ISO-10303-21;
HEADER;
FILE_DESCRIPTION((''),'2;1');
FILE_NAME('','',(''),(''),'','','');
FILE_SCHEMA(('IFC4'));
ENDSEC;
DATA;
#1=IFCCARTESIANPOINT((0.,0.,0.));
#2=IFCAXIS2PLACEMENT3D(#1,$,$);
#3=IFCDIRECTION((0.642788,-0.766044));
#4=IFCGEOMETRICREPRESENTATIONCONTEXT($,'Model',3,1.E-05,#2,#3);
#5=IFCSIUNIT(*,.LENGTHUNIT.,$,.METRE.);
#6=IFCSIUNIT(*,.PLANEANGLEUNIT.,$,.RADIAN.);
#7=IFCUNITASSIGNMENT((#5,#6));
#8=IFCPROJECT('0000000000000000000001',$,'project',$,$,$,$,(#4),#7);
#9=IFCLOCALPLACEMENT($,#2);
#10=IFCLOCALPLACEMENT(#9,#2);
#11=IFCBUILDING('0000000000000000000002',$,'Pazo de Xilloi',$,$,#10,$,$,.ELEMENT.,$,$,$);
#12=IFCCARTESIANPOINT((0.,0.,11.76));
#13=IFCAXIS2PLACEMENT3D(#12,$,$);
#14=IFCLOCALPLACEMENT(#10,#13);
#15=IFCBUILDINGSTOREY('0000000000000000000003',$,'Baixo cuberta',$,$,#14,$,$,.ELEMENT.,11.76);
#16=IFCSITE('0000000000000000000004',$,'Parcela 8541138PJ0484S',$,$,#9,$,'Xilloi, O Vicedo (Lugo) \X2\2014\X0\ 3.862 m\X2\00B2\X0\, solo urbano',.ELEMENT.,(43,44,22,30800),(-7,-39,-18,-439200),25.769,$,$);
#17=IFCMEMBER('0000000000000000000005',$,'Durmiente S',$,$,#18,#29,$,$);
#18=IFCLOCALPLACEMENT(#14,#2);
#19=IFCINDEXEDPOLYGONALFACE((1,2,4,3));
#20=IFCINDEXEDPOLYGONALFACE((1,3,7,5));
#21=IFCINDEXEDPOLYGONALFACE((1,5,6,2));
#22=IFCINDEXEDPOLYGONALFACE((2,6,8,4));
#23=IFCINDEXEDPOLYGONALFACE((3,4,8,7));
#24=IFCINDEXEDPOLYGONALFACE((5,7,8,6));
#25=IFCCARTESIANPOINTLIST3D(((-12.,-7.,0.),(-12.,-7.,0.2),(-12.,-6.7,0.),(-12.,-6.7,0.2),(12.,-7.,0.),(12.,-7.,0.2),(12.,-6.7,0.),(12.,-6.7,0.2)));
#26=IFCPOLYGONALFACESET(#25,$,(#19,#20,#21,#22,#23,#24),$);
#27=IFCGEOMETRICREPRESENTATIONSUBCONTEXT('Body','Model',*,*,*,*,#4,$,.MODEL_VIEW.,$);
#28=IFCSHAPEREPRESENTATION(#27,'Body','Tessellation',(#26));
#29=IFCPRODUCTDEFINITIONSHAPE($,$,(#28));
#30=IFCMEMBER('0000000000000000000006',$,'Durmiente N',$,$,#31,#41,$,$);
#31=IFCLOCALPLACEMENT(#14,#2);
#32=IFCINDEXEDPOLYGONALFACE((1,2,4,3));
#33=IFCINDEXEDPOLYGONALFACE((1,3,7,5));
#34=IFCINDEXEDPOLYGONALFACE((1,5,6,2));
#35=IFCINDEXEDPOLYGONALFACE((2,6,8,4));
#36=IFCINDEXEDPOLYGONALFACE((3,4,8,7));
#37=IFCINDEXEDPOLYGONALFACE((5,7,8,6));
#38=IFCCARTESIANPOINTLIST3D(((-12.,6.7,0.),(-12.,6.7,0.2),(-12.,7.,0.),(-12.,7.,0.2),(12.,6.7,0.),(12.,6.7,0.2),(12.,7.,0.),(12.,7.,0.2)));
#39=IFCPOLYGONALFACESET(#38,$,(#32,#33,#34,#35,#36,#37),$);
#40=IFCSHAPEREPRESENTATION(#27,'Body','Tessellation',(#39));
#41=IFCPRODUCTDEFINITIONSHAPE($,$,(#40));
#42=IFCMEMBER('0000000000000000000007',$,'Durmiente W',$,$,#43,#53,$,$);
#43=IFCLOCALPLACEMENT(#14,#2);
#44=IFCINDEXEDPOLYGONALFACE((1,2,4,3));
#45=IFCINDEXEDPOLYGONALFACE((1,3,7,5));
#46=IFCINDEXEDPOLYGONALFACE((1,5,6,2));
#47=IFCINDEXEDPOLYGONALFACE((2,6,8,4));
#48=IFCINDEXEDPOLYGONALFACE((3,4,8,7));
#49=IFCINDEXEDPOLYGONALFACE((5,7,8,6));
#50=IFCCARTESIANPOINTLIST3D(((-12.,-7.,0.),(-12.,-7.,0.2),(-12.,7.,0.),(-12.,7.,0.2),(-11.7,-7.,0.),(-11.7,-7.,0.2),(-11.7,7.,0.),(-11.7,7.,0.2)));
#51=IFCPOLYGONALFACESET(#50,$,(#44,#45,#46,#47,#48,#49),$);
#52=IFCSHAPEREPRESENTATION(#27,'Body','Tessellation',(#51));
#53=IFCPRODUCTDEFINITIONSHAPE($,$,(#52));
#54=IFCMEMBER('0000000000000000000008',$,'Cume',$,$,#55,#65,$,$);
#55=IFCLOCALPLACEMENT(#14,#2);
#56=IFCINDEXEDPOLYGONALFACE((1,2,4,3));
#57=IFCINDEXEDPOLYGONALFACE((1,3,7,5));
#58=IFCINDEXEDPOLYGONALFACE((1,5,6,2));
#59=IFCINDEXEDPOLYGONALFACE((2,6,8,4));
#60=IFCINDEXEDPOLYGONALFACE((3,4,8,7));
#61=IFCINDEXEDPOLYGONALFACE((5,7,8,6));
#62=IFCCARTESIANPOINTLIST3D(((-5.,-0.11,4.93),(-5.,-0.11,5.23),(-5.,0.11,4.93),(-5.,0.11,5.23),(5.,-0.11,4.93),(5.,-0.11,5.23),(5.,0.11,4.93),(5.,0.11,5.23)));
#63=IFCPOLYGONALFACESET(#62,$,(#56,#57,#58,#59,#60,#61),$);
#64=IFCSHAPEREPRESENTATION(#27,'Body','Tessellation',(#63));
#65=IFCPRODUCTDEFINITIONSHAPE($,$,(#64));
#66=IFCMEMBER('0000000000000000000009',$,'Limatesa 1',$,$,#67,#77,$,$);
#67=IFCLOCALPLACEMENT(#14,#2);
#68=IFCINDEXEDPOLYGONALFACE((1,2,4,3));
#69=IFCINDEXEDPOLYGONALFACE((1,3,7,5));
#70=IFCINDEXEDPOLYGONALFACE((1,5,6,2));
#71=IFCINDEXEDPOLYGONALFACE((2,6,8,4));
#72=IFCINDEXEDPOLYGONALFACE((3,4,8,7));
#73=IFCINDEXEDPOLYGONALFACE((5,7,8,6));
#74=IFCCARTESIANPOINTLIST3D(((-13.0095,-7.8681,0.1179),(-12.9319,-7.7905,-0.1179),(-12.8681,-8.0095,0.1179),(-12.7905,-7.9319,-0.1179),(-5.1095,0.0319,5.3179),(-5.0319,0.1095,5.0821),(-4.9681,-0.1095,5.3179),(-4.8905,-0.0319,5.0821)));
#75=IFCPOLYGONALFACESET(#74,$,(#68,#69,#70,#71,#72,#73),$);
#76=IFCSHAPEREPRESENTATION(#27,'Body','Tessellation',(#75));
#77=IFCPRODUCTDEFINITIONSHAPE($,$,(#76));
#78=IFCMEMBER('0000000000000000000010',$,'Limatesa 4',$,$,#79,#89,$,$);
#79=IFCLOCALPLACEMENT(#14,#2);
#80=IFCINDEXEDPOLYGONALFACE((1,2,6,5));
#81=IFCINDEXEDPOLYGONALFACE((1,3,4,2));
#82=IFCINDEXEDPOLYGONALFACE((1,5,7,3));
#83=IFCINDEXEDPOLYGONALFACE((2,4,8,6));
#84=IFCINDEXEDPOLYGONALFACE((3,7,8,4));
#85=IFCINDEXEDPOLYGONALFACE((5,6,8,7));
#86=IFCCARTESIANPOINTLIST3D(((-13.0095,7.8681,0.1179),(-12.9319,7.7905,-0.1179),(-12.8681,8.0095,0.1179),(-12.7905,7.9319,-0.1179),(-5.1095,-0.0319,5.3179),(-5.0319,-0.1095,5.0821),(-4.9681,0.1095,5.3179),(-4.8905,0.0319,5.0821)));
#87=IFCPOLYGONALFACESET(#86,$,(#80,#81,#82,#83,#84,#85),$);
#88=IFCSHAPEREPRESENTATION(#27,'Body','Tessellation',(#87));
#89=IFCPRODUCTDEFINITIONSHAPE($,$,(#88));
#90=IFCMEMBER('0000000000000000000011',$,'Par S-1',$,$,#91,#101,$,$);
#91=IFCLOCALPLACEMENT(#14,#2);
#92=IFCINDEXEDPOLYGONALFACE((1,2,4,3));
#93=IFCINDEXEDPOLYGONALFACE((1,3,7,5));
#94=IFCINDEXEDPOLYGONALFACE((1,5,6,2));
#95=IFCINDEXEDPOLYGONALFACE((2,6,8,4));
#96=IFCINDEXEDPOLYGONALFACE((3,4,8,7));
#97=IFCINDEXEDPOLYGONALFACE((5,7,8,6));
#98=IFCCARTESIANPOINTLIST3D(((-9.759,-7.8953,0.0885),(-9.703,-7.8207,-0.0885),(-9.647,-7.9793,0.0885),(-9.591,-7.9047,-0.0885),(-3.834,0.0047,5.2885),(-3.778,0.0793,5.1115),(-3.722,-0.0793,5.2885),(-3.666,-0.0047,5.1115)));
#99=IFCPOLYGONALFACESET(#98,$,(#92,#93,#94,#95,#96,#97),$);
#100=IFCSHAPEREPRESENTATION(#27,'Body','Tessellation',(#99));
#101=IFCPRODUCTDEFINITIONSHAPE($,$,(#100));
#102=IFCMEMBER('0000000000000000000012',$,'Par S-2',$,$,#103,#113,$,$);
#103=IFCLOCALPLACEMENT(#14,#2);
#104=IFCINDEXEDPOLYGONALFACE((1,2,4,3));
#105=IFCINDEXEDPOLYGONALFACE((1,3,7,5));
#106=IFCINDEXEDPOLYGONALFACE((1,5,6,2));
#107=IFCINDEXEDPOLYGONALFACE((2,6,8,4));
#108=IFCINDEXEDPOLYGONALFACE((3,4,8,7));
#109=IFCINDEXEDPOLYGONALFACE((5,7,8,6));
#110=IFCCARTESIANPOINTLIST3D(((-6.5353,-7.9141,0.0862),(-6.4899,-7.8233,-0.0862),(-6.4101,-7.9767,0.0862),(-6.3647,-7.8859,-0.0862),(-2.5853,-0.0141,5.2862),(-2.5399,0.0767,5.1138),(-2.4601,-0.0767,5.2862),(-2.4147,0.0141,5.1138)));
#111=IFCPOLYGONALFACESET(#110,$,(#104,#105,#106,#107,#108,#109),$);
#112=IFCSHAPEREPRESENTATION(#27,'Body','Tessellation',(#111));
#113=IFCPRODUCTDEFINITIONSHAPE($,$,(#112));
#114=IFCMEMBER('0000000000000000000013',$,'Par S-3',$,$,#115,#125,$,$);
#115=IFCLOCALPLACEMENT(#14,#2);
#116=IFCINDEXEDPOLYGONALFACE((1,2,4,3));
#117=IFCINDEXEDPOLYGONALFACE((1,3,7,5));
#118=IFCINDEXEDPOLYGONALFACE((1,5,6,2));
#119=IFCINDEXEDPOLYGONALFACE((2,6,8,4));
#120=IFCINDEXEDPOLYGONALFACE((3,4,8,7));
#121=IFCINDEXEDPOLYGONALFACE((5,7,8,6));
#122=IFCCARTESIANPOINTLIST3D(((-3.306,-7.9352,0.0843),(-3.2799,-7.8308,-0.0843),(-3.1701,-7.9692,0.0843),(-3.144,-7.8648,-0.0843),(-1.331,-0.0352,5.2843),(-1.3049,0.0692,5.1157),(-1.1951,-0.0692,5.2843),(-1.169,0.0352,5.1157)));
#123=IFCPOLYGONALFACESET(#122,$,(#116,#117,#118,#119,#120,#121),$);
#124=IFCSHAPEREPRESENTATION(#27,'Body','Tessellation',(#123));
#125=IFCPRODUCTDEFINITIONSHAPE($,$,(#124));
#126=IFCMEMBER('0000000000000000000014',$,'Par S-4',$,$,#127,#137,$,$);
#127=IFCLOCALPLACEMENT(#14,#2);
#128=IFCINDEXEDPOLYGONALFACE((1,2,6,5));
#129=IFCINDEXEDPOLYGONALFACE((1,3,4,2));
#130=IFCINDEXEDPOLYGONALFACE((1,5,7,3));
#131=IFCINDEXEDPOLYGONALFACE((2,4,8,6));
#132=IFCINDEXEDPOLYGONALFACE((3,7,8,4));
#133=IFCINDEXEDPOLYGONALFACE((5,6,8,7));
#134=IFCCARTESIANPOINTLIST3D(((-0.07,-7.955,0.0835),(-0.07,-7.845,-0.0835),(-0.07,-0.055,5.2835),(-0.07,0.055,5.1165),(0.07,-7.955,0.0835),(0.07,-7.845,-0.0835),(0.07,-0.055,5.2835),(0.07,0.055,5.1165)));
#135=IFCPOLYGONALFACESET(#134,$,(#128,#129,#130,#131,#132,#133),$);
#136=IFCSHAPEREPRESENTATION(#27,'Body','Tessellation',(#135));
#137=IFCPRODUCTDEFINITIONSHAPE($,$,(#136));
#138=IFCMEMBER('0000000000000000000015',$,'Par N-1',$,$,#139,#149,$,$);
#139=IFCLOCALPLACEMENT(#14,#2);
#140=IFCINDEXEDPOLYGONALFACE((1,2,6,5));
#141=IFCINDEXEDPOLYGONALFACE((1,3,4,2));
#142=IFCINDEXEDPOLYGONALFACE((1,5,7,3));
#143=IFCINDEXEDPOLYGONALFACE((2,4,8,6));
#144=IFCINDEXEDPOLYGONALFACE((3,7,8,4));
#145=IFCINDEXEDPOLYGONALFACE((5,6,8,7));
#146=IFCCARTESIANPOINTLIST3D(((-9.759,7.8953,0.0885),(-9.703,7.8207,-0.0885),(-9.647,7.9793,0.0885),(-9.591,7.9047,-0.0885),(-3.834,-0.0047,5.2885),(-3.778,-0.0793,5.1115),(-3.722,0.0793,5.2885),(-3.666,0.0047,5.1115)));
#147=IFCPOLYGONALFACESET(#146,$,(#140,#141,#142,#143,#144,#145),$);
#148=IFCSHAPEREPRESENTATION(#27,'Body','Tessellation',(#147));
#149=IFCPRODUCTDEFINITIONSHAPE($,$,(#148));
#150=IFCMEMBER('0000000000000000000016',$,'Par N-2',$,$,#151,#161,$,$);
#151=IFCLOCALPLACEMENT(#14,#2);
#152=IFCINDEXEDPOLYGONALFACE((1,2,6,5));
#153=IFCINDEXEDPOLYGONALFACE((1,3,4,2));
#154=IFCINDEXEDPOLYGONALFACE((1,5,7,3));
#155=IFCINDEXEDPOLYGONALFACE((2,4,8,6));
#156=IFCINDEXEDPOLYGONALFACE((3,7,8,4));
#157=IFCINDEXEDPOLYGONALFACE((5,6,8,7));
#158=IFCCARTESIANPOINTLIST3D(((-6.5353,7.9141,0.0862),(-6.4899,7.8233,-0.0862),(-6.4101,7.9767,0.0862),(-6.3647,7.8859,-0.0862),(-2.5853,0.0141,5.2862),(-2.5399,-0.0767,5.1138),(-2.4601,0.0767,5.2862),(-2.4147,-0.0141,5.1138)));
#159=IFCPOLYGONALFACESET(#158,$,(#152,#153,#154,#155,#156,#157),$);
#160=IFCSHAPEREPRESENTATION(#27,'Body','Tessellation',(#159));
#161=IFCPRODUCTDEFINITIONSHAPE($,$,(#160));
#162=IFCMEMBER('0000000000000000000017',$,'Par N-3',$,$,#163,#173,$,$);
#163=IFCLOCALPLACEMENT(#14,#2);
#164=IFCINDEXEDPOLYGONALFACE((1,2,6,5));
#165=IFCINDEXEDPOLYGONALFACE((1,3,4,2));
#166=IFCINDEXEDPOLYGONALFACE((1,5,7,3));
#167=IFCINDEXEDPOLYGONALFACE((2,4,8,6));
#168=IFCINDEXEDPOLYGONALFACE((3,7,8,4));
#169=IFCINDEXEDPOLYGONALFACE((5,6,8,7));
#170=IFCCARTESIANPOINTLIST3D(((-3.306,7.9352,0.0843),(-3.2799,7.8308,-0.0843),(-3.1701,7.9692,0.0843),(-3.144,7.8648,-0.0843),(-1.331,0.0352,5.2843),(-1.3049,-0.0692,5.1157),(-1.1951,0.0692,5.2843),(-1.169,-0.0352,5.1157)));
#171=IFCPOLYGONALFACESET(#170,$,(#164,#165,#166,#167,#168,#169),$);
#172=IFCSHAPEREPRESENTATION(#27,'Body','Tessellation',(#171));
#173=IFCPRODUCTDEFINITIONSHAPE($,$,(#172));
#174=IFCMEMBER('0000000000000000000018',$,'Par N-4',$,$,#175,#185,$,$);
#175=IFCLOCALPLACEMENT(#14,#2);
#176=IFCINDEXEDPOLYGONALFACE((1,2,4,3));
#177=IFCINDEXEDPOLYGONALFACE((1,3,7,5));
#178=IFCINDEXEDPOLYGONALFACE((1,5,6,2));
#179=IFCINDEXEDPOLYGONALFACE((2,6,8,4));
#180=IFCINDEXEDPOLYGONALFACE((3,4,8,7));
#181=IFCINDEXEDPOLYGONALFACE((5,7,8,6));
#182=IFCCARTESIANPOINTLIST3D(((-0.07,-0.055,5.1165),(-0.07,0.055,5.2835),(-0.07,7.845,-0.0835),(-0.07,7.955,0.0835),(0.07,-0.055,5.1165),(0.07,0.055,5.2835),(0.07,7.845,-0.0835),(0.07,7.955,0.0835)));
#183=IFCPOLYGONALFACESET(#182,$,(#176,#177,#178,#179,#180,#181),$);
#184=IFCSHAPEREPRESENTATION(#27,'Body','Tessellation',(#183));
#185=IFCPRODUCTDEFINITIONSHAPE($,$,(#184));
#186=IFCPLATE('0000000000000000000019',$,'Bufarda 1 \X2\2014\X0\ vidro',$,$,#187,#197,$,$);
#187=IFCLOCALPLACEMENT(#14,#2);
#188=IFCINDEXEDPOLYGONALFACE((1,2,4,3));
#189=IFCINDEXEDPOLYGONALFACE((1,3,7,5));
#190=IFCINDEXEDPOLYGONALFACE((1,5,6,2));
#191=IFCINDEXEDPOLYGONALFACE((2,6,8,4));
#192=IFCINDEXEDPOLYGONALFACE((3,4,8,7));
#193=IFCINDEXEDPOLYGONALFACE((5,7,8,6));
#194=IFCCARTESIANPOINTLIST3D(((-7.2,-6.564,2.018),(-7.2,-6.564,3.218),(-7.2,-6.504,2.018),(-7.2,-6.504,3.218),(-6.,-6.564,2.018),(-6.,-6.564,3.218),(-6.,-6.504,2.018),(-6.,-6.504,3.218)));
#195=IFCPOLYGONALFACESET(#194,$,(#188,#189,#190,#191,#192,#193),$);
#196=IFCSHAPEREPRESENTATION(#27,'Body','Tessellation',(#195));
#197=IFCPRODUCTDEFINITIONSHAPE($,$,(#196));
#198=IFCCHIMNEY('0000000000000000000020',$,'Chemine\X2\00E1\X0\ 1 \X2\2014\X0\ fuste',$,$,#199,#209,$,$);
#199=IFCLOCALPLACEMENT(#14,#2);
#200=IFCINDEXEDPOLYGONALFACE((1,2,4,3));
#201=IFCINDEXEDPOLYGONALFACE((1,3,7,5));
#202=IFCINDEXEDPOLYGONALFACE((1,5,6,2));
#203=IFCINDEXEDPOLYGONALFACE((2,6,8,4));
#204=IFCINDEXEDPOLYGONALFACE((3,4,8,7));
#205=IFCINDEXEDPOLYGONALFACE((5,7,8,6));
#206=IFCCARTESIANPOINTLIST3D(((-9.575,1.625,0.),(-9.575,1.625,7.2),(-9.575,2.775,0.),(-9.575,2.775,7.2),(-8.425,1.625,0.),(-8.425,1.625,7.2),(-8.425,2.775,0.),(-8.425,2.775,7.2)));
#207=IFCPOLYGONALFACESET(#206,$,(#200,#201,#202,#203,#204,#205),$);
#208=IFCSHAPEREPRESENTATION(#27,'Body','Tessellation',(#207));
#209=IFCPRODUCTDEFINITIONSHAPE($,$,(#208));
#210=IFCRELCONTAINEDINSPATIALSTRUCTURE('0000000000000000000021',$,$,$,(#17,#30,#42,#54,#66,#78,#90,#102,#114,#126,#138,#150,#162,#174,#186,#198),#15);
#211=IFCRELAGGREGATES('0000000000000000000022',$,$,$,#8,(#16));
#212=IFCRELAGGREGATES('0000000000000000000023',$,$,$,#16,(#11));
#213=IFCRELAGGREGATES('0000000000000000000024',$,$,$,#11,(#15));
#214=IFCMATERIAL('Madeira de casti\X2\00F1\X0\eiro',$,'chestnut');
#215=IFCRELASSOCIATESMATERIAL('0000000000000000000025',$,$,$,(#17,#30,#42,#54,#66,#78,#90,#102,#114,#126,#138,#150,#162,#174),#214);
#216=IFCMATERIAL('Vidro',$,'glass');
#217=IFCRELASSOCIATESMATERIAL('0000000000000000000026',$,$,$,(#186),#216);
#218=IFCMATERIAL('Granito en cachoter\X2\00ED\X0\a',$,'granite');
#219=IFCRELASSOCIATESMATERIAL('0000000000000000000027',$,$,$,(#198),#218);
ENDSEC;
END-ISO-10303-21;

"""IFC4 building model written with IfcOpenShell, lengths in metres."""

from ifc_helpers import new_model, si_unit, direction, frame, origin, origin_2d, place, context, subcontext, project, spatial, rectangle, extrude, material, element, save


model = new_model("IFC4")

# Units and contexts
model_context = context("Model", 3, precision=1e-05, world=origin(), true_north=direction((0.642788, -0.766044)))
body_context = subcontext(model_context, "Body", "Model", "MODEL_VIEW")
ifc_project = project(units=[si_unit("LENGTHUNIT", "METRE"), si_unit("PLANEANGLEUNIT", "RADIAN")], contexts=[model_context])

# Site, building, storey
site_placement = place(None, origin())
site = spatial("IfcSite", under=ifc_project, at=site_placement, Name="Parcela 8541138PJ0484S", LongName="Xilloi, O Vicedo (Lugo) — 3.862 m², solo urbano", CompositionType="ELEMENT", RefLatitude=(43, 44, 22, 30800), RefLongitude=(-7, -39, -18, -439200), RefElevation=25.769)
building_placement = place(site_placement, origin())
building = spatial("IfcBuilding", under=site, at=building_placement, Name="Pazo de Xilloi", CompositionType="ELEMENT")
storey_placement = place(building_placement, frame((0.0, 0.0, 11.76)))
storey = spatial("IfcBuildingStorey", under=building, at=storey_placement, Name="Baixo cuberta", CompositionType="ELEMENT", Elevation=11.76)

# Members
ifc_material_1 = material(Name="Madeira de castiñeiro", Category="chestnut")
for number, where, name in (
    (1, (0.0, -6.85, 0.1), "Durmiente S"),
    (2, (0.0, 6.85, 0.1), "Durmiente N"),
):
    element("IfcMember", number, at=place(storey_placement, frame(where)), inside=storey, material=ifc_material_1, Name=name, context=body_context, shape_type="SweptSolid", body=[
        extrude(rectangle(XDim=24.0, YDim=0.3, at=origin_2d()), frame((0.0, 0.0, -0.1)), (0.0, 0.0, 1.0), 0.2),
    ])
member_1_placement = place(storey_placement, frame((-11.85, 0.0, 0.1)))
element("IfcMember", 3, at=member_1_placement, inside=storey, material=ifc_material_1, Name="Durmiente W", context=body_context, shape_type="SweptSolid", body=[
    extrude(rectangle(XDim=0.3, YDim=14.0, at=origin_2d()), frame((0.0, 0.0, -0.1)), (0.0, 0.0, 1.0), 0.2),
])
member_2_placement = place(storey_placement, frame((0.0, 0.0, 5.08)))
element("IfcMember", 4, at=member_2_placement, inside=storey, material=ifc_material_1, Name="Cume", context=body_context, shape_type="SweptSolid", body=[
    extrude(rectangle(XDim=10.0, YDim=0.22, at=origin_2d()), frame((0.0, 0.0, -0.15)), (0.0, 0.0, 1.0), 0.3),
])
for number, where, z_axis, x_axis, name in (
    (5, (-8.95, -3.95, 2.6), (-0.298378, -0.298378, 0.90661), (0.64107, 0.64107, 0.42197), "Limatesa 1"),
    (6, (-8.95, 3.95, 2.6), (-0.298378, 0.298378, 0.90661), (0.64107, -0.64107, 0.42197), "Limatesa 4"),
):
    element("IfcMember", number, at=place(storey_placement, frame(where, z_axis=z_axis, x_axis=x_axis)), inside=storey, material=ifc_material_1, Name=name, context=body_context, shape_type="SweptSolid", body=[
        extrude(rectangle(XDim=12.3231, YDim=0.2, at=origin_2d()), frame((0.0, 0.0, -0.13)), (0.0, 0.0, 1.0), 0.26),
    ])
member_3_placement = place(storey_placement, frame((-6.7125, -3.95, 2.6), z_axis=(-0.279559, -0.372745, 0.884821), x_axis=(0.530893, 0.707857, 0.465931)))
element("IfcMember", 7, at=member_3_placement, inside=storey, material=ifc_material_1, Name="Par S-1", context=body_context, shape_type="SweptSolid", body=[
    extrude(rectangle(XDim=11.1604, YDim=0.14, at=origin_2d()), frame((0.0, 0.0, -0.1)), (0.0, 0.0, 1.0), 0.2),
])
member_4_placement = place(storey_placement, frame((-4.475, -3.95, 2.6), z_axis=(-0.22689, -0.45378, 0.861745), x_axis=(0.385384, 0.770768, 0.507341)))
element("IfcMember", 8, at=member_4_placement, inside=storey, material=ifc_material_1, Name="Par S-2", context=body_context, shape_type="SweptSolid", body=[
    extrude(rectangle(XDim=10.2495, YDim=0.14, at=origin_2d()), frame((0.0, 0.0, -0.1)), (0.0, 0.0, 1.0), 0.2),
])
member_5_placement = place(storey_placement, frame((-2.2375, -3.95, 2.6), z_axis=(-0.130533, -0.522132, 0.842816), x_axis=(0.204413, 0.817652, 0.538201)))
element("IfcMember", 9, at=member_5_placement, inside=storey, material=ifc_material_1, Name="Par S-3", context=body_context, shape_type="SweptSolid", body=[
    extrude(rectangle(XDim=9.6618, YDim=0.14, at=origin_2d()), frame((0.0, 0.0, -0.1)), (0.0, 0.0, 1.0), 0.2),
])
member_6_placement = place(storey_placement, frame((0.0, -3.95, 2.6), z_axis=(0.0, -0.549811, 0.835289), x_axis=(0.0, 0.835289, 0.549811)))
element("IfcMember", 10, at=member_6_placement, inside=storey, material=ifc_material_1, Name="Par S-4", context=body_context, shape_type="SweptSolid", body=[
    extrude(rectangle(XDim=9.4578, YDim=0.14, at=origin_2d()), frame((0.0, 0.0, -0.1)), (0.0, 0.0, 1.0), 0.2),
])
member_7_placement = place(storey_placement, frame((-6.7125, 3.95, 2.6), z_axis=(-0.279559, 0.372745, 0.884821), x_axis=(0.530893, -0.707857, 0.465931)))
element("IfcMember", 11, at=member_7_placement, inside=storey, material=ifc_material_1, Name="Par N-1", context=body_context, shape_type="SweptSolid", body=[
    extrude(rectangle(XDim=11.1604, YDim=0.14, at=origin_2d()), frame((0.0, 0.0, -0.1)), (0.0, 0.0, 1.0), 0.2),
])
member_8_placement = place(storey_placement, frame((-4.475, 3.95, 2.6), z_axis=(-0.22689, 0.45378, 0.861745), x_axis=(0.385384, -0.770768, 0.507341)))
element("IfcMember", 12, at=member_8_placement, inside=storey, material=ifc_material_1, Name="Par N-2", context=body_context, shape_type="SweptSolid", body=[
    extrude(rectangle(XDim=10.2495, YDim=0.14, at=origin_2d()), frame((0.0, 0.0, -0.1)), (0.0, 0.0, 1.0), 0.2),
])
member_9_placement = place(storey_placement, frame((-2.2375, 3.95, 2.6), z_axis=(-0.130533, 0.522132, 0.842816), x_axis=(0.204413, -0.817652, 0.538201)))
element("IfcMember", 13, at=member_9_placement, inside=storey, material=ifc_material_1, Name="Par N-3", context=body_context, shape_type="SweptSolid", body=[
    extrude(rectangle(XDim=9.6618, YDim=0.14, at=origin_2d()), frame((0.0, 0.0, -0.1)), (0.0, 0.0, 1.0), 0.2),
])
member_10_placement = place(storey_placement, frame((0.0, 3.95, 2.6), z_axis=(0.0, 0.549811, 0.835289), x_axis=(0.0, -0.835289, 0.549811)))
element("IfcMember", 14, at=member_10_placement, inside=storey, material=ifc_material_1, Name="Par N-4", context=body_context, shape_type="SweptSolid", body=[
    extrude(rectangle(XDim=9.4578, YDim=0.14, at=origin_2d()), frame((0.0, 0.0, -0.1)), (0.0, 0.0, 1.0), 0.2),
])

# Plate
ifc_material_2 = material(Name="Vidro", Category="glass")
plate_placement = place(storey_placement, frame((-6.6, -6.534, 2.618)))
element("IfcPlate", 15, at=plate_placement, inside=storey, material=ifc_material_2, Name="Bufarda 1 — vidro", context=body_context, shape_type="SweptSolid", body=[
    extrude(rectangle(XDim=1.2, YDim=0.06, at=origin_2d()), frame((0.0, 0.0, -0.6)), (0.0, 0.0, 1.0), 1.2),
])

# Chimney
ifc_material_3 = material(Name="Granito en cachotería", Category="granite")
chimney_1_placement = place(storey_placement, frame((-9.0, 2.2, 3.6)))
element("IfcChimney", 16, at=chimney_1_placement, inside=storey, material=ifc_material_3, Name="Chemineá 1 — fuste", context=body_context, shape_type="SweptSolid", body=[
    extrude(rectangle(XDim=1.15, YDim=1.15, at=origin_2d()), frame((0.0, 0.0, -3.6)), (0.0, 0.0, 1.0), 7.2),
])

save(model, "model.ifc")
